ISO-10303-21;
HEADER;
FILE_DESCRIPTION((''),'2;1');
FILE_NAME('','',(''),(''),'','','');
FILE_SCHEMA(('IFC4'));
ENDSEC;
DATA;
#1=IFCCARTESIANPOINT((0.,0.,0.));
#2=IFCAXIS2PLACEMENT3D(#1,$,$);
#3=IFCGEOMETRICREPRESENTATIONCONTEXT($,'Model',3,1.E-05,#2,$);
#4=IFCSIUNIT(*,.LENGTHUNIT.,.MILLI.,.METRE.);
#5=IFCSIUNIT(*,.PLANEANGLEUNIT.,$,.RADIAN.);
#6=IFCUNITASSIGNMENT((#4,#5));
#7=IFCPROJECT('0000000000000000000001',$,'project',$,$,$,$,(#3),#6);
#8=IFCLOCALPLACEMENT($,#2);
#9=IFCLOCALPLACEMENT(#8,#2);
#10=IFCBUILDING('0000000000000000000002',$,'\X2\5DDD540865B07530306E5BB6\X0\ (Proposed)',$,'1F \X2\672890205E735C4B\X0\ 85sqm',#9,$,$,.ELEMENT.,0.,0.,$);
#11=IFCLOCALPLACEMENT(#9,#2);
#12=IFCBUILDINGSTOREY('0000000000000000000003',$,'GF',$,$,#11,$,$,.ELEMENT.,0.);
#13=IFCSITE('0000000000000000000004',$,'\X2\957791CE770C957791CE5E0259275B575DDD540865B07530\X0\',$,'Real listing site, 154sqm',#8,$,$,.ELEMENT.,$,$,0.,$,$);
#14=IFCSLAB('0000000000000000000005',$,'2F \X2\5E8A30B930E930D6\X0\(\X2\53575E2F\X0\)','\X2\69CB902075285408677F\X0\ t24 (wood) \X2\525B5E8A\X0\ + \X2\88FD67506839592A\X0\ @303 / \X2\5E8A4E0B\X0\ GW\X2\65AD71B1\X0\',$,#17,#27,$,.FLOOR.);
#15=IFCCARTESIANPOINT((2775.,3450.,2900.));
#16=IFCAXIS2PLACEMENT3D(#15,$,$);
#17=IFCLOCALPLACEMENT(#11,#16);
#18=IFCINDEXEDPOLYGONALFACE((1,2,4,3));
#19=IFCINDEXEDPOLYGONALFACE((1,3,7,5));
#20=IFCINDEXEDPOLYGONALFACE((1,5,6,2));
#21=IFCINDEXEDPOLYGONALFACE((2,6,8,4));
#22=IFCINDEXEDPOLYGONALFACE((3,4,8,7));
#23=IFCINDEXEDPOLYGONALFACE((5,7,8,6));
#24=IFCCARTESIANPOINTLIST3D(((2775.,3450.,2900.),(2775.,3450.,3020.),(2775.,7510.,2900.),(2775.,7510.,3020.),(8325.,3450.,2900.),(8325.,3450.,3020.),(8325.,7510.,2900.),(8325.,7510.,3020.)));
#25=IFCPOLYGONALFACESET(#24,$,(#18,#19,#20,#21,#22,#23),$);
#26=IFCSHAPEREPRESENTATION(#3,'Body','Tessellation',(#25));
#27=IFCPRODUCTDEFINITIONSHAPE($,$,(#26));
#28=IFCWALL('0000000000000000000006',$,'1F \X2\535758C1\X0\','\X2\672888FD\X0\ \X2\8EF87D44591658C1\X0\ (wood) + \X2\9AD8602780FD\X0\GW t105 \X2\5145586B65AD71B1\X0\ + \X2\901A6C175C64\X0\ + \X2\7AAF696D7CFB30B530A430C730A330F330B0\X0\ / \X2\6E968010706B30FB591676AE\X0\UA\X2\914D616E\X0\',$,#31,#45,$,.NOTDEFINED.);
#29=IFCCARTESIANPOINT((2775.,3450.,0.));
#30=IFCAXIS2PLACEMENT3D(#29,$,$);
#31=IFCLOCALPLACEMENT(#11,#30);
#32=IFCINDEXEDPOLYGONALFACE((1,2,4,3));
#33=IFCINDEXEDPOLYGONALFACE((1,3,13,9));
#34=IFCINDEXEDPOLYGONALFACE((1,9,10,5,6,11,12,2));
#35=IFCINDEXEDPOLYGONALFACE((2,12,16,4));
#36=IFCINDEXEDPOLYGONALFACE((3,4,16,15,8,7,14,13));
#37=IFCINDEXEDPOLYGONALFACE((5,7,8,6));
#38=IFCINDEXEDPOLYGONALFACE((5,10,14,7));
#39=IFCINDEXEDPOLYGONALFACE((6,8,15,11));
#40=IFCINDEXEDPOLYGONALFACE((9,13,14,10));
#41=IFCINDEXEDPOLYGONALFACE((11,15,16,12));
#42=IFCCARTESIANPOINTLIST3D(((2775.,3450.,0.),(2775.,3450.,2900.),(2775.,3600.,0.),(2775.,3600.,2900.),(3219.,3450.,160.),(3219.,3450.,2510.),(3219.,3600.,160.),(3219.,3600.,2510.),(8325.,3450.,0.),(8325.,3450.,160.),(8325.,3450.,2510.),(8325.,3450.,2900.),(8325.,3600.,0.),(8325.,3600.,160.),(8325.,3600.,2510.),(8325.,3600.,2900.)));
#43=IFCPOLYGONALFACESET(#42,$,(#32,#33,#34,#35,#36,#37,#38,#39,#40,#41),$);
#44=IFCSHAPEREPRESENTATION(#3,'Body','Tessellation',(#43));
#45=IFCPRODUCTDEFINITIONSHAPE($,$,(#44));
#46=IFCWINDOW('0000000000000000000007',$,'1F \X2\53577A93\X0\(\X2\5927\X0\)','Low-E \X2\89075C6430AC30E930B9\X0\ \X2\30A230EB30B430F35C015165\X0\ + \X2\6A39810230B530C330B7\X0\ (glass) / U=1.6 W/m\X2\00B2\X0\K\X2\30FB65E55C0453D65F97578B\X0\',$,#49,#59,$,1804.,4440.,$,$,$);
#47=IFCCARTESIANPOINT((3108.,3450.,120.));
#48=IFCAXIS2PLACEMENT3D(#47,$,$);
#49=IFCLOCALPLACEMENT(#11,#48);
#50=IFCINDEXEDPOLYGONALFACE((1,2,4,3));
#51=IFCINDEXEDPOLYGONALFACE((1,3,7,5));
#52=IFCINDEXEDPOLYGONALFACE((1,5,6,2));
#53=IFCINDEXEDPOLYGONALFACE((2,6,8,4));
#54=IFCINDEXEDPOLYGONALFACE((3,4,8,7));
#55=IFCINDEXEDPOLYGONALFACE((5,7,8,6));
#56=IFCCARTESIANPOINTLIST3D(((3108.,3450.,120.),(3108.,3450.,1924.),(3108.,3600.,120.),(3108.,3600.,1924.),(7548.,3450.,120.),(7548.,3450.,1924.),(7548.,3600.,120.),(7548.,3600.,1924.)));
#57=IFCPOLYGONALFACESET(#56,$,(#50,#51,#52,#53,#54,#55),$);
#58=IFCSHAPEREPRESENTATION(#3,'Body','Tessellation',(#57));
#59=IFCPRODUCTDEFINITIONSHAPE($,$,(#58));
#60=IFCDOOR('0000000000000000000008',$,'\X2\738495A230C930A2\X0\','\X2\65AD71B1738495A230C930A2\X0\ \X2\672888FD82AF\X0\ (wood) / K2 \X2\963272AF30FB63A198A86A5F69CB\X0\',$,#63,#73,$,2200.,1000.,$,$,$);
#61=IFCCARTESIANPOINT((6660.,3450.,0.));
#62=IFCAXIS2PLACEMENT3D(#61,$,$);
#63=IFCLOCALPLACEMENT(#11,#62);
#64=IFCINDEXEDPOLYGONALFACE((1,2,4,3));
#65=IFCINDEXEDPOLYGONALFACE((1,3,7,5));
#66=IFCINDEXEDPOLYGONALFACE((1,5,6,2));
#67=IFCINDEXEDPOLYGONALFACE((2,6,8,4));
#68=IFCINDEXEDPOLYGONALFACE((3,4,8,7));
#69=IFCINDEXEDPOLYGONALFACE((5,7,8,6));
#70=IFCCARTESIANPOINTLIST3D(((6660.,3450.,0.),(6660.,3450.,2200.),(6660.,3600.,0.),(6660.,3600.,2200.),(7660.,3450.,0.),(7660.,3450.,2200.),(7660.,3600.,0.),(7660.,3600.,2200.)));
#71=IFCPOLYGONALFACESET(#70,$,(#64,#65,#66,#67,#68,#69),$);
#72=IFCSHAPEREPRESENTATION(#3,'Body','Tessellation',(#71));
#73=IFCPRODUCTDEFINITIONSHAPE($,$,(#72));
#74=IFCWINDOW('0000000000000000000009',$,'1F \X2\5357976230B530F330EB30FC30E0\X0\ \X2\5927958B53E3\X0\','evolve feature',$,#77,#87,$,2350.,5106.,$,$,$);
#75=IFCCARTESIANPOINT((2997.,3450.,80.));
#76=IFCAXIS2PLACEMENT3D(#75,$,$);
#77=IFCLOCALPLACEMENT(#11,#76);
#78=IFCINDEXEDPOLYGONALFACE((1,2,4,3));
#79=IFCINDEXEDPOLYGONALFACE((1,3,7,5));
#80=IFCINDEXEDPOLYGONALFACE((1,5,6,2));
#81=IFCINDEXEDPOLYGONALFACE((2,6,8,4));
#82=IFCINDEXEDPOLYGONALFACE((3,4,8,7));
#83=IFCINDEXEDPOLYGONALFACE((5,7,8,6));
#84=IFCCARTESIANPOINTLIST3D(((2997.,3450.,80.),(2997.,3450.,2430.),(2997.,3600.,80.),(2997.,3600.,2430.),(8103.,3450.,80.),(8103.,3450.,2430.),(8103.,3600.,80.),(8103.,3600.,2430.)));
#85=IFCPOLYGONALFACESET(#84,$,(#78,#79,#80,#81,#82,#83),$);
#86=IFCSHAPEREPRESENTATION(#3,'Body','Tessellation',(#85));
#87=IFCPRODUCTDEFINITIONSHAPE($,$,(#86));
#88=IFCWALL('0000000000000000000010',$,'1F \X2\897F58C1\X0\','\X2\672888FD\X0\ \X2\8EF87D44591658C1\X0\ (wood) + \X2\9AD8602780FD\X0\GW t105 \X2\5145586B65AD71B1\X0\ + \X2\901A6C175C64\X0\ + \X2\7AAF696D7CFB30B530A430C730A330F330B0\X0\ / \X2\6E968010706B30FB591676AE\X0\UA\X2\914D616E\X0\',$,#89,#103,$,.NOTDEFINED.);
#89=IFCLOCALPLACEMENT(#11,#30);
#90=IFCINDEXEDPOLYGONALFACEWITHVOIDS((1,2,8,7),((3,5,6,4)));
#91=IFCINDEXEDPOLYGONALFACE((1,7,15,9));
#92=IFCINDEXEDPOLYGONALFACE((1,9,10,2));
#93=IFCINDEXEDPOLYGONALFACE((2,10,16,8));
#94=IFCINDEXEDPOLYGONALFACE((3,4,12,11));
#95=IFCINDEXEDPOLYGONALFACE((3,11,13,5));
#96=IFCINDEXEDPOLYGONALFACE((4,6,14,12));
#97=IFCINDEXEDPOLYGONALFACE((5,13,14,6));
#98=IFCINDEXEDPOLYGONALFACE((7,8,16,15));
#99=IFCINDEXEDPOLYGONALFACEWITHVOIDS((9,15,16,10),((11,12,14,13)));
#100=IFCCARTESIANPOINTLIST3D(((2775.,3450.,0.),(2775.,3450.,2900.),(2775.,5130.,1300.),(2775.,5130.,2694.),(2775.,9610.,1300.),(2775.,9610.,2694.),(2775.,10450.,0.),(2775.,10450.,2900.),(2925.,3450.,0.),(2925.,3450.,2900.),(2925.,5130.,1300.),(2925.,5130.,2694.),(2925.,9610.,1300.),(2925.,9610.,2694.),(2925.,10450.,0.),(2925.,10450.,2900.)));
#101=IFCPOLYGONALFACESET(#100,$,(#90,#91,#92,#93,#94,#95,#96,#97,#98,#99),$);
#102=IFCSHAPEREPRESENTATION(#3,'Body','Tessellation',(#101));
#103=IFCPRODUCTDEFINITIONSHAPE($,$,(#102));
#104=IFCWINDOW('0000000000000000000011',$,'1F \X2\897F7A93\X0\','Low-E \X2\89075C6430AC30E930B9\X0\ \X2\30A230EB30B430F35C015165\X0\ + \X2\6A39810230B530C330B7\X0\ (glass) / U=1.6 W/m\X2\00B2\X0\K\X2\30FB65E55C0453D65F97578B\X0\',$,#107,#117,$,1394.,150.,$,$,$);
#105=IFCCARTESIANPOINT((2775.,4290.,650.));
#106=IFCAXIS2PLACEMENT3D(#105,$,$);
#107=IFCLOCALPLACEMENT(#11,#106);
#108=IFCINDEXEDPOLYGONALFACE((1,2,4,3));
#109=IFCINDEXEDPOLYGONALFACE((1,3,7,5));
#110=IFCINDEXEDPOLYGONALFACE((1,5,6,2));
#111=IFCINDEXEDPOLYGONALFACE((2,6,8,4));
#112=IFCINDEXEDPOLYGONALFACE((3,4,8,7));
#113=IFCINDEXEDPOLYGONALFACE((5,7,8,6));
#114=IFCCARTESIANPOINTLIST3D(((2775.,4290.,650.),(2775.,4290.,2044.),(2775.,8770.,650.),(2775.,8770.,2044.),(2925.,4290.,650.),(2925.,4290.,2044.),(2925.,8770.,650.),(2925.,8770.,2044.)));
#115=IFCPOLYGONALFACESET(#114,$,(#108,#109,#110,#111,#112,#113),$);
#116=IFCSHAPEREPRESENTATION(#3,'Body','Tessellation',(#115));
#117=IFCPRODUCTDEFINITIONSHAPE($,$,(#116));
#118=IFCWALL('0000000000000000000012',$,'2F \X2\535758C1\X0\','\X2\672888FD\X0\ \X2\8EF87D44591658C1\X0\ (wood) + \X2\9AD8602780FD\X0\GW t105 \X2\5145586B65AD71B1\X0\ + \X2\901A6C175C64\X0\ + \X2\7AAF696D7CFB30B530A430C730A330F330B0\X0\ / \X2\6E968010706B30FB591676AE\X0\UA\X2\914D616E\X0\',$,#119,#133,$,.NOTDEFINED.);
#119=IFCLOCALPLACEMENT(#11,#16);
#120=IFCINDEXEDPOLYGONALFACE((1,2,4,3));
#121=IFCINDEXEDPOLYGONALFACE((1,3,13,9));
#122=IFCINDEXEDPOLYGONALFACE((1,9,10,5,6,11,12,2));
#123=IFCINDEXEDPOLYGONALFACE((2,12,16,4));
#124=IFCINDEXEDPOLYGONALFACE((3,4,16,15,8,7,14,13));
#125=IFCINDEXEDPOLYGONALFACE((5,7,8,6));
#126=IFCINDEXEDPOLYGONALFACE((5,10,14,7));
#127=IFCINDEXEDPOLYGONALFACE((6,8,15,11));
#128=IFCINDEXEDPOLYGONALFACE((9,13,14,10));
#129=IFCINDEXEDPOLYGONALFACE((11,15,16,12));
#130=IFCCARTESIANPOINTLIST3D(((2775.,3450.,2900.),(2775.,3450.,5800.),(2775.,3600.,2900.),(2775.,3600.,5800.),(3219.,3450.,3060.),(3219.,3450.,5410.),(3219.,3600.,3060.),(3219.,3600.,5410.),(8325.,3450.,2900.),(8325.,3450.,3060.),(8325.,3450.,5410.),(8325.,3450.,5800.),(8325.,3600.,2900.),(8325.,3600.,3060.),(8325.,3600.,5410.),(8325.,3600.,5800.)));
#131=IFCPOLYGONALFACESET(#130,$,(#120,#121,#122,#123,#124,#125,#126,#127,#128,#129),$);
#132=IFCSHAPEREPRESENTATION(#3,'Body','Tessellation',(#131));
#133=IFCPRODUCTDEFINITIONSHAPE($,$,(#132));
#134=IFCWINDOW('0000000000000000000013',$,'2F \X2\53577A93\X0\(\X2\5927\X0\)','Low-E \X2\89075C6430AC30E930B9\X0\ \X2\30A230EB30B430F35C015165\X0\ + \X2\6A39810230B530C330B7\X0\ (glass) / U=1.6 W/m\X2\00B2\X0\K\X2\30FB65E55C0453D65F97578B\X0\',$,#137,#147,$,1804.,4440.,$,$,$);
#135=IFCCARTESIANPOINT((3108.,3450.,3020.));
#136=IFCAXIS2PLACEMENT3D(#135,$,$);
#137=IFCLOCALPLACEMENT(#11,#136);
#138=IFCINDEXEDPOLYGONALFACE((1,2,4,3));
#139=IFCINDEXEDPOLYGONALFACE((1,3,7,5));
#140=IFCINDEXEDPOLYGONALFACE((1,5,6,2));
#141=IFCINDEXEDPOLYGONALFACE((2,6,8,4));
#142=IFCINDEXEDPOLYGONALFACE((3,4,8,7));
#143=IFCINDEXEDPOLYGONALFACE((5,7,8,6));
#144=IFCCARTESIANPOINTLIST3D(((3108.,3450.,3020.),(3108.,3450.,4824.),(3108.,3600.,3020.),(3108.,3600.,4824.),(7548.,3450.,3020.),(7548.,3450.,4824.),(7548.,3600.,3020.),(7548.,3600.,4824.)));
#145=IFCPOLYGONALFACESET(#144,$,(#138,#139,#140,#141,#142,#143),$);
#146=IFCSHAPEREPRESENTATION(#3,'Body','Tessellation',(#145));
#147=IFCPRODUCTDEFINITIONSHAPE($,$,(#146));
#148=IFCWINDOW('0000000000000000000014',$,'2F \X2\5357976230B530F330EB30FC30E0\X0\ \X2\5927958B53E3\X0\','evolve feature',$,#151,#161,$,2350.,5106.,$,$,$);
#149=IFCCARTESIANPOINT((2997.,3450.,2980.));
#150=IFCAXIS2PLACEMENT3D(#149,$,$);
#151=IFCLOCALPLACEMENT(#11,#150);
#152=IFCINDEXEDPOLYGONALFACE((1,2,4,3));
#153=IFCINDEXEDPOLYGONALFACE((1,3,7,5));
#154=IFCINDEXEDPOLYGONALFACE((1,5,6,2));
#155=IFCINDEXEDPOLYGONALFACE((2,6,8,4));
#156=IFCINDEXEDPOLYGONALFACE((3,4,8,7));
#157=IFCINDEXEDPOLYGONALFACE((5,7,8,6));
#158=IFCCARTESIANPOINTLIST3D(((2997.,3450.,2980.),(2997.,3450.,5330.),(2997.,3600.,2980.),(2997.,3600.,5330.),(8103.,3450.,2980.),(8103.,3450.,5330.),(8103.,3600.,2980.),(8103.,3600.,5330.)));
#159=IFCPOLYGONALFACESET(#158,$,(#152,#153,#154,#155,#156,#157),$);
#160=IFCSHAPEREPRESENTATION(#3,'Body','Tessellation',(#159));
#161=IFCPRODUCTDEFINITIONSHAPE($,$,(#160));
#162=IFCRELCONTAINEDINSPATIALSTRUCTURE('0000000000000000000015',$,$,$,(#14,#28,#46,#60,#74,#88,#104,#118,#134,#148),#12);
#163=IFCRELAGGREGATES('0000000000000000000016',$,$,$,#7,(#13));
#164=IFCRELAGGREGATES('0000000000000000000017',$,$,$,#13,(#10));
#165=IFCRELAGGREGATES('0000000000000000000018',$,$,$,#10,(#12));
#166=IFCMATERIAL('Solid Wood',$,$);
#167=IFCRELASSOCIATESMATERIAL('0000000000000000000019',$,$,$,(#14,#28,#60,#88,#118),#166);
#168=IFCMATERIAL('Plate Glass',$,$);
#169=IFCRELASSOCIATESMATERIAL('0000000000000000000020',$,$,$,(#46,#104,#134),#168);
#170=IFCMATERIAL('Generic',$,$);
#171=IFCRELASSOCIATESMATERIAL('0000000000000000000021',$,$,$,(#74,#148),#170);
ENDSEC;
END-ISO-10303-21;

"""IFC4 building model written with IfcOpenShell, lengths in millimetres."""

from ifc_helpers import new_model, si_unit, frame, frame_2d, origin, place, context, project, spatial, rectangle, extrude, material, element, fill, save


model = new_model("IFC4")

# Units and contexts
model_context = context("Model", 3, precision=1e-05, world=origin())
ifc_project = project(units=[si_unit("LENGTHUNIT", "METRE", prefix="MILLI"), si_unit("PLANEANGLEUNIT", "RADIAN")], contexts=[model_context])

# Site, building, storey
site_placement = place(None, origin())
site = spatial("IfcSite", under=ifc_project, at=site_placement, Name="長野県長野市大字川合新田", ObjectType="Real listing site, 154sqm", CompositionType="ELEMENT", RefElevation=0.0)
building_placement = place(site_placement, origin())
building = spatial("IfcBuilding", under=site, at=building_placement, Name="川合新田の家 (Proposed)", ObjectType="1F 木造平屋 85sqm", CompositionType="ELEMENT", ElevationOfRefHeight=0.0, ElevationOfTerrain=0.0)
storey_placement = place(building_placement, origin())
storey = spatial("IfcBuildingStorey", under=building, at=storey_placement, Name="GF", CompositionType="ELEMENT", Elevation=0.0)

# Slab
ifc_material_1 = material(Name="Solid Wood")
slab_1_placement = place(storey_placement, frame((2775.0, 3450.0, 2900.0)))
element("IfcSlab", 1, at=slab_1_placement, inside=storey, material=ifc_material_1, Name="2F 床スラブ(南帯)", Description="構造用合板 t24 (wood) 剛床 + 製材根太 @303 / 床下 GW断熱", PredefinedType="FLOOR", context=model_context, shape_type="SweptSolid", body=[
    extrude(rectangle(XDim=5550.0, YDim=4060.0, at=frame_2d((2775.0, 2030.0))), frame((2775.0, 3450.0, 2900.0)), (0.0, 0.0, 1.0), 120.0),
])
ifc_material_2 = material(Name="Generic")

# Wall, openings, windows, door
wall_1_placement = place(storey_placement, frame((2775.0, 3450.0, 0.0)))
wall_1 = element("IfcWall", 2, at=wall_1_placement, inside=storey, material=ifc_material_1, Name="1F 南壁", Description="木製 軸組外壁 (wood) + 高性能GW t105 充填断熱 + 通気層 + 窯業系サイディング / 準耐火・外皮UA配慮", PredefinedType="NOTDEFINED", context=model_context, shape_type="SweptSolid", body=[
    extrude(rectangle(XDim=5550.0, YDim=150.0, at=frame_2d((2775.0, 75.0))), frame((2775.0, 3450.0, 0.0)), (0.0, 0.0, 1.0), 2900.0),
])
opening_1_placement = place(storey_placement, frame((3108.0, 3450.0, 120.0)))
opening_1 = element("IfcOpeningElement", 3, at=opening_1_placement, cuts=wall_1, PredefinedType="NOTDEFINED", context=model_context, shape_type="SweptSolid", body=[
    extrude(rectangle(XDim=4440.0, YDim=150.0, at=frame_2d((2220.0, 75.0))), frame((3108.0, 3450.0, 120.0)), (0.0, 0.0, 1.0), 1804.0),
])
opening_2_placement = place(storey_placement, frame((6660.0, 3450.0, 0.0)))
opening_2 = element("IfcOpeningElement", 4, at=opening_2_placement, cuts=wall_1, PredefinedType="NOTDEFINED", context=model_context, shape_type="SweptSolid", body=[
    extrude(rectangle(XDim=1000.0, YDim=150.0, at=frame_2d((500.0, 75.0))), frame((6660.0, 3450.0, 0.0)), (0.0, 0.0, 1.0), 2200.0),
])
opening_3_placement = place(storey_placement, frame((2997.0, 3450.0, 80.0)))
opening_3 = element("IfcOpeningElement", 5, at=opening_3_placement, cuts=wall_1, PredefinedType="NOTDEFINED", context=model_context, shape_type="SweptSolid", body=[
    extrude(rectangle(XDim=5106.0, YDim=150.0, at=frame_2d((2553.0, 75.0))), frame((2997.0, 3450.0, 80.0)), (0.0, 0.0, 1.0), 2350.0),
])
ifc_material_3 = material(Name="Plate Glass")
window_1_placement = place(storey_placement, frame((3108.0, 3450.0, 120.0)))
window_1 = element("IfcWindow", 6, at=window_1_placement, inside=storey, material=ifc_material_3, Name="1F 南窓(大)", Description="Low-E 複層ガラス アルゴン封入 + 樹脂サッシ (glass) / U=1.6 W/m²K・日射取得型", OverallHeight=1804.0, OverallWidth=4440.0, context=model_context, shape_type="SweptSolid", body=[
    extrude(rectangle(XDim=4440.0, YDim=150.0, at=frame_2d((2220.0, 75.0))), frame((3108.0, 3450.0, 120.0)), (0.0, 0.0, 1.0), 1804.0),
])
fill(opening_1, window_1)
door_placement = place(storey_placement, frame((6660.0, 3450.0, 0.0)))
door = element("IfcDoor", 7, at=door_placement, inside=storey, material=ifc_material_1, Name="玄関ドア", Description="断熱玄関ドア 木製芯 (wood) / K2 防犯・採風機構", OverallHeight=2200.0, OverallWidth=1000.0, context=model_context, shape_type="SweptSolid", body=[
    extrude(rectangle(XDim=1000.0, YDim=150.0, at=frame_2d((500.0, 75.0))), frame((6660.0, 3450.0, 0.0)), (0.0, 0.0, 1.0), 2200.0),
])
fill(opening_2, door)
window_2_placement = place(storey_placement, frame((2997.0, 3450.0, 80.0)))
window_2 = element("IfcWindow", 8, at=window_2_placement, inside=storey, material=ifc_material_2, Name="1F 南面サンルーム 大開口", Description="evolve feature", OverallHeight=2350.0, OverallWidth=5106.0, context=model_context, shape_type="SweptSolid", body=[
    extrude(rectangle(XDim=5106.0, YDim=150.0, at=frame_2d((2553.0, 75.0))), frame((2997.0, 3450.0, 80.0)), (0.0, 0.0, 1.0), 2350.0),
])
fill(opening_3, window_2)

# Wall, opening, window
wall_2_placement = place(storey_placement, frame((2775.0, 3450.0, 0.0)))
wall_2 = element("IfcWall", 9, at=wall_2_placement, inside=storey, material=ifc_material_1, Name="1F 西壁", Description="木製 軸組外壁 (wood) + 高性能GW t105 充填断熱 + 通気層 + 窯業系サイディング / 準耐火・外皮UA配慮", PredefinedType="NOTDEFINED", context=model_context, shape_type="SweptSolid", body=[
    extrude(rectangle(XDim=150.0, YDim=7000.0, at=frame_2d((75.0, 3500.0))), frame((2775.0, 3450.0, 0.0)), (0.0, 0.0, 1.0), 2900.0),
])
opening_4_placement = place(storey_placement, frame((2775.0, 4290.0, 650.0)))
opening_4 = element("IfcOpeningElement", 10, at=opening_4_placement, cuts=wall_2, PredefinedType="NOTDEFINED", context=model_context, shape_type="SweptSolid", body=[
    extrude(rectangle(XDim=150.0, YDim=4480.0, at=frame_2d((75.0, 2240.0))), frame((2775.0, 4290.0, 650.0)), (0.0, 0.0, 1.0), 1394.0),
])
window_3_placement = place(storey_placement, frame((2775.0, 4290.0, 650.0)))
window_3 = element("IfcWindow", 11, at=window_3_placement, inside=storey, material=ifc_material_3, Name="1F 西窓", Description="Low-E 複層ガラス アルゴン封入 + 樹脂サッシ (glass) / U=1.6 W/m²K・日射取得型", OverallHeight=1394.0, OverallWidth=150.0, context=model_context, shape_type="SweptSolid", body=[
    extrude(rectangle(XDim=150.0, YDim=4480.0, at=frame_2d((75.0, 2240.0))), frame((2775.0, 4290.0, 650.0)), (0.0, 0.0, 1.0), 1394.0),
])
fill(opening_4, window_3)

# Wall, openings, windows
wall_3_placement = place(storey_placement, frame((2775.0, 3450.0, 2900.0)))
wall_3 = element("IfcWall", 12, at=wall_3_placement, inside=storey, material=ifc_material_1, Name="2F 南壁", Description="木製 軸組外壁 (wood) + 高性能GW t105 充填断熱 + 通気層 + 窯業系サイディング / 準耐火・外皮UA配慮", PredefinedType="NOTDEFINED", context=model_context, shape_type="SweptSolid", body=[
    extrude(rectangle(XDim=5550.0, YDim=150.0, at=frame_2d((2775.0, 75.0))), frame((2775.0, 3450.0, 2900.0)), (0.0, 0.0, 1.0), 2900.0),
])
opening_5_placement = place(storey_placement, frame((3108.0, 3450.0, 3020.0)))
opening_5 = element("IfcOpeningElement", 13, at=opening_5_placement, cuts=wall_3, PredefinedType="NOTDEFINED", context=model_context, shape_type="SweptSolid", body=[
    extrude(rectangle(XDim=4440.0, YDim=150.0, at=frame_2d((2220.0, 75.0))), frame((3108.0, 3450.0, 3020.0)), (0.0, 0.0, 1.0), 1804.0),
])
opening_6_placement = place(storey_placement, frame((2997.0, 3450.0, 2980.0)))
opening_6 = element("IfcOpeningElement", 14, at=opening_6_placement, cuts=wall_3, PredefinedType="NOTDEFINED", context=model_context, shape_type="SweptSolid", body=[
    extrude(rectangle(XDim=5106.0, YDim=150.0, at=frame_2d((2553.0, 75.0))), frame((2997.0, 3450.0, 2980.0)), (0.0, 0.0, 1.0), 2350.0),
])
window_4_placement = place(storey_placement, frame((3108.0, 3450.0, 3020.0)))
window_4 = element("IfcWindow", 15, at=window_4_placement, inside=storey, material=ifc_material_3, Name="2F 南窓(大)", Description="Low-E 複層ガラス アルゴン封入 + 樹脂サッシ (glass) / U=1.6 W/m²K・日射取得型", OverallHeight=1804.0, OverallWidth=4440.0, context=model_context, shape_type="SweptSolid", body=[
    extrude(rectangle(XDim=4440.0, YDim=150.0, at=frame_2d((2220.0, 75.0))), frame((3108.0, 3450.0, 3020.0)), (0.0, 0.0, 1.0), 1804.0),
])
fill(opening_5, window_4)
window_5_placement = place(storey_placement, frame((2997.0, 3450.0, 2980.0)))
window_5 = element("IfcWindow", 16, at=window_5_placement, inside=storey, material=ifc_material_2, Name="2F 南面サンルーム 大開口", Description="evolve feature", OverallHeight=2350.0, OverallWidth=5106.0, context=model_context, shape_type="SweptSolid", body=[
    extrude(rectangle(XDim=5106.0, YDim=150.0, at=frame_2d((2553.0, 75.0))), frame((2997.0, 3450.0, 2980.0)), (0.0, 0.0, 1.0), 2350.0),
])
fill(opening_6, window_5)

save(model, "model.ifc")
